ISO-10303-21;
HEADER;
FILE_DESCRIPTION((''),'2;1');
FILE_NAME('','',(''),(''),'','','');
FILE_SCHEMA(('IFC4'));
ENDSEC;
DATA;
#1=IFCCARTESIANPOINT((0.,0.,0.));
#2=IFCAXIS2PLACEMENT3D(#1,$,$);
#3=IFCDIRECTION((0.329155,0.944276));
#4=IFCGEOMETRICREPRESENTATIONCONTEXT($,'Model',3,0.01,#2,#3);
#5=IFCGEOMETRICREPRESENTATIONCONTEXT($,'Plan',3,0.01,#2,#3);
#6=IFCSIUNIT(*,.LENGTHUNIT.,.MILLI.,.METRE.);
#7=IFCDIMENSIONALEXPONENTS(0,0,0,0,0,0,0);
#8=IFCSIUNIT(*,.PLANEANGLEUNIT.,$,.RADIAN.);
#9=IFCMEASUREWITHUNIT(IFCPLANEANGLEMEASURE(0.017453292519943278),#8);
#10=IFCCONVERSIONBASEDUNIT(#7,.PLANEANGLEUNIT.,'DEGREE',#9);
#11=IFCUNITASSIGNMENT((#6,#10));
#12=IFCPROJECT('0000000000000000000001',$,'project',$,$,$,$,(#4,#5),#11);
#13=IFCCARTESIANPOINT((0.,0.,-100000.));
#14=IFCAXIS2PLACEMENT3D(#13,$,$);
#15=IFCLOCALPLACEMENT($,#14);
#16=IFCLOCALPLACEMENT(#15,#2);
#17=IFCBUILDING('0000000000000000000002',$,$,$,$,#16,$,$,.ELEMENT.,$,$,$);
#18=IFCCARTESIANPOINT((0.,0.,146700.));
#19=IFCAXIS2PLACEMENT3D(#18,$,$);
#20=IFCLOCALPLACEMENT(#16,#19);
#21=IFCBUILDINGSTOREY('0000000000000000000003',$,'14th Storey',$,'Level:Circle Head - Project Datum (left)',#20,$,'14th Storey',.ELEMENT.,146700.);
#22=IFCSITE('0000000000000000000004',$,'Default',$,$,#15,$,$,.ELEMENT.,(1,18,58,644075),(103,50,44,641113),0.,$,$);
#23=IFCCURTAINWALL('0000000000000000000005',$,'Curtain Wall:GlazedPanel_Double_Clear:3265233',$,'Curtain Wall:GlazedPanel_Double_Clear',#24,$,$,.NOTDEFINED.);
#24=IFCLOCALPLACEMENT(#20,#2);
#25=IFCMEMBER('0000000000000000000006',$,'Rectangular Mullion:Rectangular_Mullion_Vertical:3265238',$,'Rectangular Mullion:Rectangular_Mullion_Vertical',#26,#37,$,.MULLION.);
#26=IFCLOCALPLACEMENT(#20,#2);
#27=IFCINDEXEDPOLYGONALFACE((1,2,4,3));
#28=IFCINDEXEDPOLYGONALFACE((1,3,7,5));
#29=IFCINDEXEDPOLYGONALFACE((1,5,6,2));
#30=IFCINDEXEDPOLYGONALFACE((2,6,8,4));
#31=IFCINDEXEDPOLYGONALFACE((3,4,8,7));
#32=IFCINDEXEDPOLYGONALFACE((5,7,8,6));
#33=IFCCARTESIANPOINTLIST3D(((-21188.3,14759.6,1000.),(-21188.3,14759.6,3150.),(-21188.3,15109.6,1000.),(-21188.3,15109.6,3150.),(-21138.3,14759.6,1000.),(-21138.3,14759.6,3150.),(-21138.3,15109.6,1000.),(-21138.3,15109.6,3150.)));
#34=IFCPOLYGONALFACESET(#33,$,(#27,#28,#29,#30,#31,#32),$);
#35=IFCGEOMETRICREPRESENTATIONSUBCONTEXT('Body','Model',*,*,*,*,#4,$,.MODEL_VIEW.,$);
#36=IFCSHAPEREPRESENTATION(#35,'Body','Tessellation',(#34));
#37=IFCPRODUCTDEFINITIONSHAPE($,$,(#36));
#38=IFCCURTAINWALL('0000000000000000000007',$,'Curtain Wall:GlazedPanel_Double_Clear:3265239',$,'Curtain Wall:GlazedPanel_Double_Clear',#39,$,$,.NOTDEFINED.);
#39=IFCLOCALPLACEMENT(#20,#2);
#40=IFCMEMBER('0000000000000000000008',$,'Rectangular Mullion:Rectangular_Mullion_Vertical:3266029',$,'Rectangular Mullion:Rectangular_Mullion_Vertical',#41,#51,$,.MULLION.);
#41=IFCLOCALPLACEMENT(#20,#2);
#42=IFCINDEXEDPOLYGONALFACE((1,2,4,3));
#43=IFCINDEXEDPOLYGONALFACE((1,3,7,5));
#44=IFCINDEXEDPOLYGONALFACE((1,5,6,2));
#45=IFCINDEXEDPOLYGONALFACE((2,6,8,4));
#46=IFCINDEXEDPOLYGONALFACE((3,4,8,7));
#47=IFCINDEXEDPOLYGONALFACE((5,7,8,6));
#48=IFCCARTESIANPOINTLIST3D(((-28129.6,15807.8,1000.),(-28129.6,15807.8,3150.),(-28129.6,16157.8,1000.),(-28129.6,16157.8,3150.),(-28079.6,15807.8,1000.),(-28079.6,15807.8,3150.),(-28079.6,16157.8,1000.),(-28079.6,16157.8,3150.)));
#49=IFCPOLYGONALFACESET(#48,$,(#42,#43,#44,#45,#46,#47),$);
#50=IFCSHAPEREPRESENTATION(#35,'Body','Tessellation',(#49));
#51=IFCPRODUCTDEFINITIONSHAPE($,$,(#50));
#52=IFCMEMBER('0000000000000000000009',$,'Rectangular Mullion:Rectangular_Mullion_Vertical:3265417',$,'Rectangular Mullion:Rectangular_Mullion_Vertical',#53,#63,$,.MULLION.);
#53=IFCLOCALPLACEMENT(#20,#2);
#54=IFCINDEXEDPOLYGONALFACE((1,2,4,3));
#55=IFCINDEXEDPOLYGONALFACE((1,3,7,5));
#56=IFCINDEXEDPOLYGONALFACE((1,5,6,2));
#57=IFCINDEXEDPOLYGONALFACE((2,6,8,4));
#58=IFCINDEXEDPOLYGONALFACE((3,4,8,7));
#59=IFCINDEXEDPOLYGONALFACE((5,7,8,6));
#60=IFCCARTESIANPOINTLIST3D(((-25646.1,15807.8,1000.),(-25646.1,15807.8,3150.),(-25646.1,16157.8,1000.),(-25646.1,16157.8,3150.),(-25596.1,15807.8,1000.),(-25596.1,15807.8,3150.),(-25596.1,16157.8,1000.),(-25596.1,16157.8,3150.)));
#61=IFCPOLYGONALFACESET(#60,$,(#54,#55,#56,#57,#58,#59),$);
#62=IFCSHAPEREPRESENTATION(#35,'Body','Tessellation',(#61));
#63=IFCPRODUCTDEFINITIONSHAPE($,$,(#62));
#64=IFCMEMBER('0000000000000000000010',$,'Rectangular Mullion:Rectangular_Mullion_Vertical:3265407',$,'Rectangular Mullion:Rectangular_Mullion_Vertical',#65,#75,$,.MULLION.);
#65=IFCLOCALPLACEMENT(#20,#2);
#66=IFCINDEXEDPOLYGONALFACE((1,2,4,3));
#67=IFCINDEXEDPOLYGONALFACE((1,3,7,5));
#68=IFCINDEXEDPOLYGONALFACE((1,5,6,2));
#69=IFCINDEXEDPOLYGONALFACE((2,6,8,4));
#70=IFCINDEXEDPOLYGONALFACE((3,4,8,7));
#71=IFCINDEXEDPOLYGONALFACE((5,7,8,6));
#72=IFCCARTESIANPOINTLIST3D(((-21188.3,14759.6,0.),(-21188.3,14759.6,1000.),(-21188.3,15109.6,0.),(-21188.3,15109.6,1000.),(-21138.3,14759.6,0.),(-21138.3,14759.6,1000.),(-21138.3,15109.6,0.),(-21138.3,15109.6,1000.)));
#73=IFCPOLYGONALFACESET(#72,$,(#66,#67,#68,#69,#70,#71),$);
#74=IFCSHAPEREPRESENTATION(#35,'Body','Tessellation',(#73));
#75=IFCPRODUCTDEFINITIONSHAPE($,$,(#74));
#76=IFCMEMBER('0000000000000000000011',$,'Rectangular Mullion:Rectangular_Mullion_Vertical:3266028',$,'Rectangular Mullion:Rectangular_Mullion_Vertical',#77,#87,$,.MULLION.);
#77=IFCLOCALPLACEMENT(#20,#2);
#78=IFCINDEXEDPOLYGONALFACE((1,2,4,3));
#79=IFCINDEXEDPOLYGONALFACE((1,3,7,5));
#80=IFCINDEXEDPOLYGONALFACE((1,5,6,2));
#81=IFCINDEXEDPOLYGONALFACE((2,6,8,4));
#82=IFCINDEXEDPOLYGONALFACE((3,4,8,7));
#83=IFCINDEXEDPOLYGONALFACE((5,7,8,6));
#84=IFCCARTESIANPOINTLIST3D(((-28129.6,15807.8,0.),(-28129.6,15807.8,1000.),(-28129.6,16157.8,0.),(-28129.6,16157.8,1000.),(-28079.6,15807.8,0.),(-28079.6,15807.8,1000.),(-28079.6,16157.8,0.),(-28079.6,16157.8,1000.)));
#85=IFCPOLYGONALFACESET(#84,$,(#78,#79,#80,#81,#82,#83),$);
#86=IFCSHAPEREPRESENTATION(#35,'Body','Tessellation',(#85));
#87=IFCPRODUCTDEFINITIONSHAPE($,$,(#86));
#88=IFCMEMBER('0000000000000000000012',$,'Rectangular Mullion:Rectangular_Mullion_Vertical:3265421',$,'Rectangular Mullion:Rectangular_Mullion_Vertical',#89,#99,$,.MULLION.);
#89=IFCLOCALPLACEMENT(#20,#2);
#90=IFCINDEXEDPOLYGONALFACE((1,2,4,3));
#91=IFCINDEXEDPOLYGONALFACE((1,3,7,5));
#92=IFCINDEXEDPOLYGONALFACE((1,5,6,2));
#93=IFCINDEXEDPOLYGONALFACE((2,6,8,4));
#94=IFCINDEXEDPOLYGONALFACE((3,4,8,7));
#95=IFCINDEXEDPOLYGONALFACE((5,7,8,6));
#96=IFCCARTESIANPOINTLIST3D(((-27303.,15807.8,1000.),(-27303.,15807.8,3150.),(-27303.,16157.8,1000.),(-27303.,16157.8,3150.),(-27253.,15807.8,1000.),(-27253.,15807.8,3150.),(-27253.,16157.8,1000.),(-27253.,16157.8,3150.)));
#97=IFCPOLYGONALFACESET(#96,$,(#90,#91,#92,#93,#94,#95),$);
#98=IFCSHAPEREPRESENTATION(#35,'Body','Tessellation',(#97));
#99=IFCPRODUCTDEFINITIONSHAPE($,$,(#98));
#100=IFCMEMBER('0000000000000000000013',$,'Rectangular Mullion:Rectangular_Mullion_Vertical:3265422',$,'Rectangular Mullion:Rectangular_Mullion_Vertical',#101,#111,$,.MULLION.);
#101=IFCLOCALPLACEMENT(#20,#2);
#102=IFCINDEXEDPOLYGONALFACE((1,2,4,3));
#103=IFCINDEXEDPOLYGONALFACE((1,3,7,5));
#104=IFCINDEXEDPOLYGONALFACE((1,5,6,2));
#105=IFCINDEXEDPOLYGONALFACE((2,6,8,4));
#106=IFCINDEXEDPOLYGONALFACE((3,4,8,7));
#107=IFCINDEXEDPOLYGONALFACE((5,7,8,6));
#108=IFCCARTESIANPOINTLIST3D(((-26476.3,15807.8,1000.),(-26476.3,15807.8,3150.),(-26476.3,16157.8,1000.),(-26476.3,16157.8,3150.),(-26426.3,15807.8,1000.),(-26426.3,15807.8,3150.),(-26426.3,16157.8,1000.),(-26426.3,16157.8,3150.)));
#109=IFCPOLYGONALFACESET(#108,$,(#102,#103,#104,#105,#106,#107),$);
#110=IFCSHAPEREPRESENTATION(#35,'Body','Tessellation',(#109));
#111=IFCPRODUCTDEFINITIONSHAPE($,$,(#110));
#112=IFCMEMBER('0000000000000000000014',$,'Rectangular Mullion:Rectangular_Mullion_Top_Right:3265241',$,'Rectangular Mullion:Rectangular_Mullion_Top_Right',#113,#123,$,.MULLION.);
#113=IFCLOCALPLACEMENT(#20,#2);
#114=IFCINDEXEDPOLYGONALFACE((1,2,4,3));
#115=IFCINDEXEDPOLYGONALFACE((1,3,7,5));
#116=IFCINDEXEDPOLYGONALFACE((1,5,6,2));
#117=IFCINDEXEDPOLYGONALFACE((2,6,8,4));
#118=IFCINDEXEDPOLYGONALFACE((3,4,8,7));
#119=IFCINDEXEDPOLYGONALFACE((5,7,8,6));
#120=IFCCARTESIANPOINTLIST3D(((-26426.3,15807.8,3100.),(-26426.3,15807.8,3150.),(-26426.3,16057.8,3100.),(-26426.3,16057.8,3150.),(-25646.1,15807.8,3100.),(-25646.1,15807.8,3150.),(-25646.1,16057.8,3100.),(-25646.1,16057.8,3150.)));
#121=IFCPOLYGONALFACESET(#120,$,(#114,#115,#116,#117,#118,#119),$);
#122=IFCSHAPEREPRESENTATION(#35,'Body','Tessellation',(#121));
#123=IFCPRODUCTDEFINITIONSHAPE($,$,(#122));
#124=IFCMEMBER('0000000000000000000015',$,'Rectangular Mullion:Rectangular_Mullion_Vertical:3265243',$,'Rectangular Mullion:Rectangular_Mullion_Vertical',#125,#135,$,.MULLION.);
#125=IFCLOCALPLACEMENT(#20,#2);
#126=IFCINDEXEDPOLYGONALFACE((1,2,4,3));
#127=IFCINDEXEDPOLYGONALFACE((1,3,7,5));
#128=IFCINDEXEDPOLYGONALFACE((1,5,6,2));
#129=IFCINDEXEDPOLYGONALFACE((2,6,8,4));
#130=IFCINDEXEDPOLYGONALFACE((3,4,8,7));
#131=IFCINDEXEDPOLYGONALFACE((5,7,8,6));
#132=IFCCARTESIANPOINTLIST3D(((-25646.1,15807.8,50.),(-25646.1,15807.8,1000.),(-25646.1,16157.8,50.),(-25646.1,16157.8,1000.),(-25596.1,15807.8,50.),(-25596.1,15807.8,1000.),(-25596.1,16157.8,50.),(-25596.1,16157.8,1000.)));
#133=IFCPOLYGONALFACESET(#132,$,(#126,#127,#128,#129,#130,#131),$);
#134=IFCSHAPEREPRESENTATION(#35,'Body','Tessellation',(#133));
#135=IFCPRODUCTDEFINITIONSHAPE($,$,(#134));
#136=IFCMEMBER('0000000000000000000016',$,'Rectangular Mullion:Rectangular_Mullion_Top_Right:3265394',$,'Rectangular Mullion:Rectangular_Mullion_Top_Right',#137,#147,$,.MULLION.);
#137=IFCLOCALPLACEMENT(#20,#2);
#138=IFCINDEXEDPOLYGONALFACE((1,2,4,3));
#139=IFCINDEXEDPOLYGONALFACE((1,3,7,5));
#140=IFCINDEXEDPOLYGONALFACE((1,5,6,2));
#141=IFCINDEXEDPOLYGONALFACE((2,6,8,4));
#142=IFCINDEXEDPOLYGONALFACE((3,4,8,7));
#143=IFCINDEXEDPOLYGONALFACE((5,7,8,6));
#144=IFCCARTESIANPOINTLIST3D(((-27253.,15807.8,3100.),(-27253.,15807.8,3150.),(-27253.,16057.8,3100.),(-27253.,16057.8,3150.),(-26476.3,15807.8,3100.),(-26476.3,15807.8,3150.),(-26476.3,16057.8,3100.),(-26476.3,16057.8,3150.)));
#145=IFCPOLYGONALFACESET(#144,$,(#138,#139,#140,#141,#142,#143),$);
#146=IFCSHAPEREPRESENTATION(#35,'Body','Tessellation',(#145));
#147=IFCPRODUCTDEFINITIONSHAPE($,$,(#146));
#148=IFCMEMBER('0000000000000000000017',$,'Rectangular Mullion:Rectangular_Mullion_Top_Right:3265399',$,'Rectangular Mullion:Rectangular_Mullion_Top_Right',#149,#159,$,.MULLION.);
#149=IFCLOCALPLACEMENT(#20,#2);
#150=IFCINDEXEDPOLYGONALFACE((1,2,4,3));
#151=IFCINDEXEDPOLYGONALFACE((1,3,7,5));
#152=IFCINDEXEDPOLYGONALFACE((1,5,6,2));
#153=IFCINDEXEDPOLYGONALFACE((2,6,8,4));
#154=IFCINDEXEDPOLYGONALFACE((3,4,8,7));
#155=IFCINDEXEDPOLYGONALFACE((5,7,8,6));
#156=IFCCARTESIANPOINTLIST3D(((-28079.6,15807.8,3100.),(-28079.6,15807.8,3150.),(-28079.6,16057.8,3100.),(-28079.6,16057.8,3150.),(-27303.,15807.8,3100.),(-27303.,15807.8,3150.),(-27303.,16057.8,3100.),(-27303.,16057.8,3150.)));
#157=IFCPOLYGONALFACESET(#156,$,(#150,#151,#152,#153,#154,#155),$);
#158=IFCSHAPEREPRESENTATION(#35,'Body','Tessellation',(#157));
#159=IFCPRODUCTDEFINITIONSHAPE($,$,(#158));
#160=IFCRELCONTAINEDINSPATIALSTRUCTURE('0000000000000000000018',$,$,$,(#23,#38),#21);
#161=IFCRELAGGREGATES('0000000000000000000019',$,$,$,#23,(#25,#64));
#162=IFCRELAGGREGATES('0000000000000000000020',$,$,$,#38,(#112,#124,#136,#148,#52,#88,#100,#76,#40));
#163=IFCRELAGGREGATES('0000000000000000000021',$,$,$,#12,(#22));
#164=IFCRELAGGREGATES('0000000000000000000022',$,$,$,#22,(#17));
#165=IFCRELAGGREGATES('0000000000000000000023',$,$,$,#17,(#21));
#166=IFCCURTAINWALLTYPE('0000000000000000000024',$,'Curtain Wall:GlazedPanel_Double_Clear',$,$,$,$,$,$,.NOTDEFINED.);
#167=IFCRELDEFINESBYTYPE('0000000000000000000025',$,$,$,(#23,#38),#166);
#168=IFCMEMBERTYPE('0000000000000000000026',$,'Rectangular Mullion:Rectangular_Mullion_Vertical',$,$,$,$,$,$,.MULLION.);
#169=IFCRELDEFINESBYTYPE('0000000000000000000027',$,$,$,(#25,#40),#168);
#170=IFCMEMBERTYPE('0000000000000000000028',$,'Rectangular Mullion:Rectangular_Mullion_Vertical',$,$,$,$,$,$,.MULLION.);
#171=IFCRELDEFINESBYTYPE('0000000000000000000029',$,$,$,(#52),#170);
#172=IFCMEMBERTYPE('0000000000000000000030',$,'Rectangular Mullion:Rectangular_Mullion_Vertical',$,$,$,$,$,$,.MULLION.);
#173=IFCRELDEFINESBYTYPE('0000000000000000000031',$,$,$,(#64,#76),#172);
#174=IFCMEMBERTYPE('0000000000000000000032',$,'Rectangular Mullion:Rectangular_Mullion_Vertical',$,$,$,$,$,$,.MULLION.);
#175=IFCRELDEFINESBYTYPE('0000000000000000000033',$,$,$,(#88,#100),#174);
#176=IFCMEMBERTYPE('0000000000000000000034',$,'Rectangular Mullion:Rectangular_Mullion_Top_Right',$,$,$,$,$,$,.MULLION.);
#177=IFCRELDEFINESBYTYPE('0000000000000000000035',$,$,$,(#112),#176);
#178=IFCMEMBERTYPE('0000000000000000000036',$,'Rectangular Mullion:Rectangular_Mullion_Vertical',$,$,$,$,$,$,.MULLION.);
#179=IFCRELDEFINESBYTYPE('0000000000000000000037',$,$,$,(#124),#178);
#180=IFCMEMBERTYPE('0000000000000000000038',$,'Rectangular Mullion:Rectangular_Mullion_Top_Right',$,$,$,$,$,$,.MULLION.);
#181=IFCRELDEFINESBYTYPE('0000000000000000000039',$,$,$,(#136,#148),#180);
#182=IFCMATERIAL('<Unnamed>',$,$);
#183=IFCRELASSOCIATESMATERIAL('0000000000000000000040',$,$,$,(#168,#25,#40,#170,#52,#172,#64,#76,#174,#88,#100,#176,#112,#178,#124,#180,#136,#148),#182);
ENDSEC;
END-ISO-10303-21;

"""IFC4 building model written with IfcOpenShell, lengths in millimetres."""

from ifc_helpers import new_model, entity, si_unit, converted_unit, direction, frame, origin, place, context, subcontext, project, spatial, indexed_curve, outline, extrude, source, transform, mapped, material, type_object, type_shapes, element, aggregate, save


model = new_model("IFC4")

# Units and contexts
model_context = context("Model", 3, precision=0.01, world=origin(), true_north=direction((0.329155, 0.944276)))
plan_context = context("Plan", 3, precision=0.01, world=origin(), true_north=direction((0.329155, 0.944276)))
body_context = subcontext(model_context, "Body", "Model", "MODEL_VIEW")
ifc_project = project(units=[si_unit("LENGTHUNIT", "METRE", prefix="MILLI"), converted_unit("PLANEANGLEUNIT", "DEGREE", entity("IfcPlaneAngleMeasure", 0.017453292519943278), si_unit("PLANEANGLEUNIT", "RADIAN"), dimensions=[0, 0, 0, 0, 0, 0, 0])], contexts=[model_context, plan_context])

# Site, building, storey
site_placement = place(None, frame((0.0, 0.0, -100000.0)))
site = spatial("IfcSite", under=ifc_project, at=site_placement, Name="Default", CompositionType="ELEMENT", RefLatitude=(1, 18, 58, 644075), RefLongitude=(103, 50, 44, 641113), RefElevation=0.0)
building_placement = place(site_placement, origin())
building = spatial("IfcBuilding", under=site, at=building_placement, CompositionType="ELEMENT")
storey_placement = place(building_placement, frame((0.0, 0.0, 146700.0)))
storey = spatial("IfcBuildingStorey", under=building, at=storey_placement, Name="14th Storey", ObjectType="Level:Circle Head - Project Datum (left)", LongName="14th Storey", CompositionType="ELEMENT", Elevation=146700.0)

# Curtain wall, member
curtain_wall_type = type_object("IfcCurtainWallType", Name="Curtain Wall:GlazedPanel_Double_Clear", PredefinedType="NOTDEFINED")
curtain_wall_1_placement = place(storey_placement, frame((0.0, 0.0, -146700.0)))
curtain_wall_1 = element("IfcCurtainWall", 1, at=curtain_wall_1_placement, inside=storey, type_object=curtain_wall_type, Name="Curtain Wall:GlazedPanel_Double_Clear:3265233", ObjectType="Curtain Wall:GlazedPanel_Double_Clear", PredefinedType="NOTDEFINED")
ifc_material_1 = material(Name="<Unnamed>")
member_type_1 = type_object("IfcMemberType", Name="Rectangular Mullion:Rectangular_Mullion_Vertical", PredefinedType="MULLION", material=ifc_material_1)
shared_shape_1 = source(origin(), body_context, "Body", "SweptSolid", [
    extrude(outline(indexed_curve([(-25.0, -175.0), (25.0, -175.0), (25.0, 175.0), (-25.0, 175.0), (-25.0, -175.0)], self_intersect=False)), frame((-25.0, -50.0, -2150.0), z_axis=(0.0, 0.0, 1.0), x_axis=(-1.0, 0.0, 0.0)), (0.0, 0.0, 1.0), 2150.0),
])
type_shapes(member_type_1, [shared_shape_1])
member_1_placement = place(curtain_wall_1_placement, frame((-21188.3, 14884.6, 149850.0), z_axis=(0.0, 0.0, 1.0), x_axis=(-1.0, 0.0, 0.0)))
member_1 = element("IfcMember", 2, at=member_1_placement, type_object=member_type_1, material=ifc_material_1, Name="Rectangular Mullion:Rectangular_Mullion_Vertical:3265238", ObjectType="Rectangular Mullion:Rectangular_Mullion_Vertical", PredefinedType="MULLION", context=body_context, shape_type="MappedRepresentation", body=[
    mapped(shared_shape_1, transform((0.0, 0.0, 0.0), scale=1.0)),
])

# Curtain wall, members
curtain_wall_2_placement = place(storey_placement, frame((0.0, 0.0, -146700.0)))
curtain_wall_2 = element("IfcCurtainWall", 3, at=curtain_wall_2_placement, inside=storey, type_object=curtain_wall_type, Name="Curtain Wall:GlazedPanel_Double_Clear:3265239", ObjectType="Curtain Wall:GlazedPanel_Double_Clear", PredefinedType="NOTDEFINED")
member_2_placement = place(curtain_wall_2_placement, frame((-28129.6, 15932.8, 149850.0), z_axis=(0.0, 0.0, 1.0), x_axis=(-1.0, 0.0, 0.0)))
member_2 = element("IfcMember", 4, at=member_2_placement, type_object=member_type_1, material=ifc_material_1, Name="Rectangular Mullion:Rectangular_Mullion_Vertical:3266029", ObjectType="Rectangular Mullion:Rectangular_Mullion_Vertical", PredefinedType="MULLION", context=body_context, shape_type="MappedRepresentation", body=[
    mapped(shared_shape_1, transform((0.0, 0.0, 0.0), scale=1.0)),
])
member_type_2 = type_object("IfcMemberType", Name="Rectangular Mullion:Rectangular_Mullion_Vertical", PredefinedType="MULLION", material=ifc_material_1)
shared_shape_2 = source(origin(), body_context, "Body", "SweptSolid", [
    extrude(outline(indexed_curve([(-25.0, -175.0), (25.0, -175.0), (25.0, 175.0), (-25.0, 175.0), (-25.0, -175.0)], self_intersect=False)), frame((-25.0, -50.0, -2150.0), z_axis=(0.0, 0.0, 1.0), x_axis=(-1.0, 0.0, 0.0)), (0.0, 0.0, 1.0), 2150.0),
])
type_shapes(member_type_2, [shared_shape_2])
member_3_placement = place(curtain_wall_2_placement, frame((-25596.1, 15932.8, 147700.0), z_axis=(0.0, 0.0, -1.0), x_axis=(1.0, 0.0, 0.0)))
member_3 = element("IfcMember", 5, at=member_3_placement, type_object=member_type_2, material=ifc_material_1, Name="Rectangular Mullion:Rectangular_Mullion_Vertical:3265417", ObjectType="Rectangular Mullion:Rectangular_Mullion_Vertical", PredefinedType="MULLION", context=body_context, shape_type="MappedRepresentation", body=[
    mapped(shared_shape_2, transform((0.0, 0.0, 0.0), scale=1.0)),
])

# Members
member_type_3 = type_object("IfcMemberType", Name="Rectangular Mullion:Rectangular_Mullion_Vertical", PredefinedType="MULLION", material=ifc_material_1)
shared_shape_3 = source(origin(), body_context, "Body", "SweptSolid", [
    extrude(outline(indexed_curve([(-25.0, -175.0), (25.0, -175.0), (25.0, 175.0), (-25.0, 175.0), (-25.0, -175.0)], self_intersect=False)), frame((-25.0, -50.0, -1000.0), z_axis=(0.0, 0.0, 1.0), x_axis=(-1.0, 0.0, 0.0)), (0.0, 0.0, 1.0), 1000.0),
])
type_shapes(member_type_3, [shared_shape_3])
member_4_placement = place(curtain_wall_1_placement, frame((-21188.3, 14884.6, 147700.0), z_axis=(0.0, 0.0, 1.0), x_axis=(-1.0, 0.0, 0.0)))
member_4 = element("IfcMember", 6, at=member_4_placement, type_object=member_type_3, material=ifc_material_1, Name="Rectangular Mullion:Rectangular_Mullion_Vertical:3265407", ObjectType="Rectangular Mullion:Rectangular_Mullion_Vertical", PredefinedType="MULLION", context=body_context, shape_type="MappedRepresentation", body=[
    mapped(shared_shape_3, transform((0.0, 0.0, 0.0), scale=1.0)),
])
member_5_placement = place(curtain_wall_2_placement, frame((-28129.6, 15932.8, 147700.0), z_axis=(0.0, 0.0, 1.0), x_axis=(-1.0, 0.0, 0.0)))
member_5 = element("IfcMember", 7, at=member_5_placement, type_object=member_type_3, material=ifc_material_1, Name="Rectangular Mullion:Rectangular_Mullion_Vertical:3266028", ObjectType="Rectangular Mullion:Rectangular_Mullion_Vertical", PredefinedType="MULLION", context=body_context, shape_type="MappedRepresentation", body=[
    mapped(shared_shape_3, transform((0.0, 0.0, 0.0), scale=1.0)),
])
member_type_4 = type_object("IfcMemberType", Name="Rectangular Mullion:Rectangular_Mullion_Vertical", PredefinedType="MULLION", material=ifc_material_1)
shared_shape_4 = source(origin(), body_context, "Body", "SweptSolid", [
    extrude(outline(indexed_curve([(-25.0, -175.0), (25.0, -175.0), (25.0, 175.0), (-25.0, 175.0), (-25.0, -175.0)], self_intersect=False)), frame((0.0, -50.0, -2150.0), z_axis=(0.0, 0.0, 1.0), x_axis=(-1.0, 0.0, 0.0)), (0.0, 0.0, 1.0), 2150.0),
])
type_shapes(member_type_4, [shared_shape_4])
member_6_placement = place(curtain_wall_2_placement, frame((-27278.0, 15932.8, 147700.0), z_axis=(0.0, 0.0, -1.0), x_axis=(1.0, 0.0, 0.0)))
member_6 = element("IfcMember", 8, at=member_6_placement, type_object=member_type_4, material=ifc_material_1, Name="Rectangular Mullion:Rectangular_Mullion_Vertical:3265421", ObjectType="Rectangular Mullion:Rectangular_Mullion_Vertical", PredefinedType="MULLION", context=body_context, shape_type="MappedRepresentation", body=[
    mapped(shared_shape_4, transform((0.0, 0.0, 0.0), scale=1.0)),
])
member_7_placement = place(curtain_wall_2_placement, frame((-26451.3, 15932.8, 147700.0), z_axis=(0.0, 0.0, -1.0), x_axis=(1.0, 0.0, 0.0)))
member_7 = element("IfcMember", 9, at=member_7_placement, type_object=member_type_4, material=ifc_material_1, Name="Rectangular Mullion:Rectangular_Mullion_Vertical:3265422", ObjectType="Rectangular Mullion:Rectangular_Mullion_Vertical", PredefinedType="MULLION", context=body_context, shape_type="MappedRepresentation", body=[
    mapped(shared_shape_4, transform((0.0, 0.0, 0.0), scale=1.0)),
])
member_type_5 = type_object("IfcMemberType", Name="Rectangular Mullion:Rectangular_Mullion_Top_Right", PredefinedType="MULLION", material=ifc_material_1)
shared_shape_5 = source(origin(), body_context, "Body", "SweptSolid", [
    extrude(outline(indexed_curve([(-25.0, -125.0), (25.0, -125.0), (25.0, 125.0), (-25.0, 125.0), (-25.0, -125.0)], self_intersect=False)), frame((-25.0, 0.0, -780.2), z_axis=(0.0, 0.0, 1.0), x_axis=(-1.0, 0.0, 0.0)), (0.0, 0.0, 1.0), 780.2),
])
type_shapes(member_type_5, [shared_shape_5])
member_8_placement = place(curtain_wall_2_placement, frame((-25646.1, 15932.8, 149850.0), z_axis=(1.0, 0.0, 0.0), x_axis=(0.0, 0.0, 1.0)))
member_8 = element("IfcMember", 10, at=member_8_placement, type_object=member_type_5, material=ifc_material_1, Name="Rectangular Mullion:Rectangular_Mullion_Top_Right:3265241", ObjectType="Rectangular Mullion:Rectangular_Mullion_Top_Right", PredefinedType="MULLION", context=body_context, shape_type="MappedRepresentation", body=[
    mapped(shared_shape_5, transform((0.0, 0.0, 0.0), scale=1.0)),
])
member_type_6 = type_object("IfcMemberType", Name="Rectangular Mullion:Rectangular_Mullion_Vertical", PredefinedType="MULLION", material=ifc_material_1)
shared_shape_6 = source(origin(), body_context, "Body", "SweptSolid", [
    extrude(outline(indexed_curve([(-25.0, -175.0), (25.0, -175.0), (25.0, 175.0), (-25.0, 175.0), (-25.0, -175.0)], self_intersect=False)), frame((-25.0, -50.0, -950.0), z_axis=(0.0, 0.0, 1.0), x_axis=(-1.0, 0.0, 0.0)), (0.0, 0.0, 1.0), 950.0),
])
type_shapes(member_type_6, [shared_shape_6])
member_9_placement = place(curtain_wall_2_placement, frame((-25596.1, 15932.8, 146750.0), z_axis=(0.0, 0.0, -1.0), x_axis=(1.0, 0.0, 0.0)))
member_9 = element("IfcMember", 11, at=member_9_placement, type_object=member_type_6, material=ifc_material_1, Name="Rectangular Mullion:Rectangular_Mullion_Vertical:3265243", ObjectType="Rectangular Mullion:Rectangular_Mullion_Vertical", PredefinedType="MULLION", context=body_context, shape_type="MappedRepresentation", body=[
    mapped(shared_shape_6, transform((0.0, 0.0, 0.0), scale=1.0)),
])
member_type_7 = type_object("IfcMemberType", Name="Rectangular Mullion:Rectangular_Mullion_Top_Right", PredefinedType="MULLION", material=ifc_material_1)
shared_shape_7 = source(origin(), body_context, "Body", "SweptSolid", [
    extrude(outline(indexed_curve([(-25.0, -125.0), (25.0, -125.0), (25.0, 125.0), (-25.0, 125.0), (-25.0, -125.0)], self_intersect=False)), frame((-25.0, 0.0, -776.7), z_axis=(0.0, 0.0, 1.0), x_axis=(-1.0, 0.0, 0.0)), (0.0, 0.0, 1.0), 776.7),
])
type_shapes(member_type_7, [shared_shape_7])
member_10_placement = place(curtain_wall_2_placement, frame((-26476.3, 15932.8, 149850.0), z_axis=(1.0, 0.0, 0.0), x_axis=(0.0, 0.0, 1.0)))
member_10 = element("IfcMember", 12, at=member_10_placement, type_object=member_type_7, material=ifc_material_1, Name="Rectangular Mullion:Rectangular_Mullion_Top_Right:3265394", ObjectType="Rectangular Mullion:Rectangular_Mullion_Top_Right", PredefinedType="MULLION", context=body_context, shape_type="MappedRepresentation", body=[
    mapped(shared_shape_7, transform((0.0, 0.0, 0.0), scale=1.0)),
])
member_11_placement = place(curtain_wall_2_placement, frame((-27303.0, 15932.8, 149850.0), z_axis=(1.0, 0.0, 0.0), x_axis=(0.0, 0.0, 1.0)))
member_11 = element("IfcMember", 13, at=member_11_placement, type_object=member_type_7, material=ifc_material_1, Name="Rectangular Mullion:Rectangular_Mullion_Top_Right:3265399", ObjectType="Rectangular Mullion:Rectangular_Mullion_Top_Right", PredefinedType="MULLION", context=body_context, shape_type="MappedRepresentation", body=[
    mapped(shared_shape_7, transform((0.0, 0.0, 0.0), scale=1.0)),
])

aggregate(curtain_wall_1, [member_1, member_4])
aggregate(curtain_wall_2, [member_8, member_9, member_10, member_11, member_3, member_6, member_7, member_5, member_2])

save(model, "model.ifc")
